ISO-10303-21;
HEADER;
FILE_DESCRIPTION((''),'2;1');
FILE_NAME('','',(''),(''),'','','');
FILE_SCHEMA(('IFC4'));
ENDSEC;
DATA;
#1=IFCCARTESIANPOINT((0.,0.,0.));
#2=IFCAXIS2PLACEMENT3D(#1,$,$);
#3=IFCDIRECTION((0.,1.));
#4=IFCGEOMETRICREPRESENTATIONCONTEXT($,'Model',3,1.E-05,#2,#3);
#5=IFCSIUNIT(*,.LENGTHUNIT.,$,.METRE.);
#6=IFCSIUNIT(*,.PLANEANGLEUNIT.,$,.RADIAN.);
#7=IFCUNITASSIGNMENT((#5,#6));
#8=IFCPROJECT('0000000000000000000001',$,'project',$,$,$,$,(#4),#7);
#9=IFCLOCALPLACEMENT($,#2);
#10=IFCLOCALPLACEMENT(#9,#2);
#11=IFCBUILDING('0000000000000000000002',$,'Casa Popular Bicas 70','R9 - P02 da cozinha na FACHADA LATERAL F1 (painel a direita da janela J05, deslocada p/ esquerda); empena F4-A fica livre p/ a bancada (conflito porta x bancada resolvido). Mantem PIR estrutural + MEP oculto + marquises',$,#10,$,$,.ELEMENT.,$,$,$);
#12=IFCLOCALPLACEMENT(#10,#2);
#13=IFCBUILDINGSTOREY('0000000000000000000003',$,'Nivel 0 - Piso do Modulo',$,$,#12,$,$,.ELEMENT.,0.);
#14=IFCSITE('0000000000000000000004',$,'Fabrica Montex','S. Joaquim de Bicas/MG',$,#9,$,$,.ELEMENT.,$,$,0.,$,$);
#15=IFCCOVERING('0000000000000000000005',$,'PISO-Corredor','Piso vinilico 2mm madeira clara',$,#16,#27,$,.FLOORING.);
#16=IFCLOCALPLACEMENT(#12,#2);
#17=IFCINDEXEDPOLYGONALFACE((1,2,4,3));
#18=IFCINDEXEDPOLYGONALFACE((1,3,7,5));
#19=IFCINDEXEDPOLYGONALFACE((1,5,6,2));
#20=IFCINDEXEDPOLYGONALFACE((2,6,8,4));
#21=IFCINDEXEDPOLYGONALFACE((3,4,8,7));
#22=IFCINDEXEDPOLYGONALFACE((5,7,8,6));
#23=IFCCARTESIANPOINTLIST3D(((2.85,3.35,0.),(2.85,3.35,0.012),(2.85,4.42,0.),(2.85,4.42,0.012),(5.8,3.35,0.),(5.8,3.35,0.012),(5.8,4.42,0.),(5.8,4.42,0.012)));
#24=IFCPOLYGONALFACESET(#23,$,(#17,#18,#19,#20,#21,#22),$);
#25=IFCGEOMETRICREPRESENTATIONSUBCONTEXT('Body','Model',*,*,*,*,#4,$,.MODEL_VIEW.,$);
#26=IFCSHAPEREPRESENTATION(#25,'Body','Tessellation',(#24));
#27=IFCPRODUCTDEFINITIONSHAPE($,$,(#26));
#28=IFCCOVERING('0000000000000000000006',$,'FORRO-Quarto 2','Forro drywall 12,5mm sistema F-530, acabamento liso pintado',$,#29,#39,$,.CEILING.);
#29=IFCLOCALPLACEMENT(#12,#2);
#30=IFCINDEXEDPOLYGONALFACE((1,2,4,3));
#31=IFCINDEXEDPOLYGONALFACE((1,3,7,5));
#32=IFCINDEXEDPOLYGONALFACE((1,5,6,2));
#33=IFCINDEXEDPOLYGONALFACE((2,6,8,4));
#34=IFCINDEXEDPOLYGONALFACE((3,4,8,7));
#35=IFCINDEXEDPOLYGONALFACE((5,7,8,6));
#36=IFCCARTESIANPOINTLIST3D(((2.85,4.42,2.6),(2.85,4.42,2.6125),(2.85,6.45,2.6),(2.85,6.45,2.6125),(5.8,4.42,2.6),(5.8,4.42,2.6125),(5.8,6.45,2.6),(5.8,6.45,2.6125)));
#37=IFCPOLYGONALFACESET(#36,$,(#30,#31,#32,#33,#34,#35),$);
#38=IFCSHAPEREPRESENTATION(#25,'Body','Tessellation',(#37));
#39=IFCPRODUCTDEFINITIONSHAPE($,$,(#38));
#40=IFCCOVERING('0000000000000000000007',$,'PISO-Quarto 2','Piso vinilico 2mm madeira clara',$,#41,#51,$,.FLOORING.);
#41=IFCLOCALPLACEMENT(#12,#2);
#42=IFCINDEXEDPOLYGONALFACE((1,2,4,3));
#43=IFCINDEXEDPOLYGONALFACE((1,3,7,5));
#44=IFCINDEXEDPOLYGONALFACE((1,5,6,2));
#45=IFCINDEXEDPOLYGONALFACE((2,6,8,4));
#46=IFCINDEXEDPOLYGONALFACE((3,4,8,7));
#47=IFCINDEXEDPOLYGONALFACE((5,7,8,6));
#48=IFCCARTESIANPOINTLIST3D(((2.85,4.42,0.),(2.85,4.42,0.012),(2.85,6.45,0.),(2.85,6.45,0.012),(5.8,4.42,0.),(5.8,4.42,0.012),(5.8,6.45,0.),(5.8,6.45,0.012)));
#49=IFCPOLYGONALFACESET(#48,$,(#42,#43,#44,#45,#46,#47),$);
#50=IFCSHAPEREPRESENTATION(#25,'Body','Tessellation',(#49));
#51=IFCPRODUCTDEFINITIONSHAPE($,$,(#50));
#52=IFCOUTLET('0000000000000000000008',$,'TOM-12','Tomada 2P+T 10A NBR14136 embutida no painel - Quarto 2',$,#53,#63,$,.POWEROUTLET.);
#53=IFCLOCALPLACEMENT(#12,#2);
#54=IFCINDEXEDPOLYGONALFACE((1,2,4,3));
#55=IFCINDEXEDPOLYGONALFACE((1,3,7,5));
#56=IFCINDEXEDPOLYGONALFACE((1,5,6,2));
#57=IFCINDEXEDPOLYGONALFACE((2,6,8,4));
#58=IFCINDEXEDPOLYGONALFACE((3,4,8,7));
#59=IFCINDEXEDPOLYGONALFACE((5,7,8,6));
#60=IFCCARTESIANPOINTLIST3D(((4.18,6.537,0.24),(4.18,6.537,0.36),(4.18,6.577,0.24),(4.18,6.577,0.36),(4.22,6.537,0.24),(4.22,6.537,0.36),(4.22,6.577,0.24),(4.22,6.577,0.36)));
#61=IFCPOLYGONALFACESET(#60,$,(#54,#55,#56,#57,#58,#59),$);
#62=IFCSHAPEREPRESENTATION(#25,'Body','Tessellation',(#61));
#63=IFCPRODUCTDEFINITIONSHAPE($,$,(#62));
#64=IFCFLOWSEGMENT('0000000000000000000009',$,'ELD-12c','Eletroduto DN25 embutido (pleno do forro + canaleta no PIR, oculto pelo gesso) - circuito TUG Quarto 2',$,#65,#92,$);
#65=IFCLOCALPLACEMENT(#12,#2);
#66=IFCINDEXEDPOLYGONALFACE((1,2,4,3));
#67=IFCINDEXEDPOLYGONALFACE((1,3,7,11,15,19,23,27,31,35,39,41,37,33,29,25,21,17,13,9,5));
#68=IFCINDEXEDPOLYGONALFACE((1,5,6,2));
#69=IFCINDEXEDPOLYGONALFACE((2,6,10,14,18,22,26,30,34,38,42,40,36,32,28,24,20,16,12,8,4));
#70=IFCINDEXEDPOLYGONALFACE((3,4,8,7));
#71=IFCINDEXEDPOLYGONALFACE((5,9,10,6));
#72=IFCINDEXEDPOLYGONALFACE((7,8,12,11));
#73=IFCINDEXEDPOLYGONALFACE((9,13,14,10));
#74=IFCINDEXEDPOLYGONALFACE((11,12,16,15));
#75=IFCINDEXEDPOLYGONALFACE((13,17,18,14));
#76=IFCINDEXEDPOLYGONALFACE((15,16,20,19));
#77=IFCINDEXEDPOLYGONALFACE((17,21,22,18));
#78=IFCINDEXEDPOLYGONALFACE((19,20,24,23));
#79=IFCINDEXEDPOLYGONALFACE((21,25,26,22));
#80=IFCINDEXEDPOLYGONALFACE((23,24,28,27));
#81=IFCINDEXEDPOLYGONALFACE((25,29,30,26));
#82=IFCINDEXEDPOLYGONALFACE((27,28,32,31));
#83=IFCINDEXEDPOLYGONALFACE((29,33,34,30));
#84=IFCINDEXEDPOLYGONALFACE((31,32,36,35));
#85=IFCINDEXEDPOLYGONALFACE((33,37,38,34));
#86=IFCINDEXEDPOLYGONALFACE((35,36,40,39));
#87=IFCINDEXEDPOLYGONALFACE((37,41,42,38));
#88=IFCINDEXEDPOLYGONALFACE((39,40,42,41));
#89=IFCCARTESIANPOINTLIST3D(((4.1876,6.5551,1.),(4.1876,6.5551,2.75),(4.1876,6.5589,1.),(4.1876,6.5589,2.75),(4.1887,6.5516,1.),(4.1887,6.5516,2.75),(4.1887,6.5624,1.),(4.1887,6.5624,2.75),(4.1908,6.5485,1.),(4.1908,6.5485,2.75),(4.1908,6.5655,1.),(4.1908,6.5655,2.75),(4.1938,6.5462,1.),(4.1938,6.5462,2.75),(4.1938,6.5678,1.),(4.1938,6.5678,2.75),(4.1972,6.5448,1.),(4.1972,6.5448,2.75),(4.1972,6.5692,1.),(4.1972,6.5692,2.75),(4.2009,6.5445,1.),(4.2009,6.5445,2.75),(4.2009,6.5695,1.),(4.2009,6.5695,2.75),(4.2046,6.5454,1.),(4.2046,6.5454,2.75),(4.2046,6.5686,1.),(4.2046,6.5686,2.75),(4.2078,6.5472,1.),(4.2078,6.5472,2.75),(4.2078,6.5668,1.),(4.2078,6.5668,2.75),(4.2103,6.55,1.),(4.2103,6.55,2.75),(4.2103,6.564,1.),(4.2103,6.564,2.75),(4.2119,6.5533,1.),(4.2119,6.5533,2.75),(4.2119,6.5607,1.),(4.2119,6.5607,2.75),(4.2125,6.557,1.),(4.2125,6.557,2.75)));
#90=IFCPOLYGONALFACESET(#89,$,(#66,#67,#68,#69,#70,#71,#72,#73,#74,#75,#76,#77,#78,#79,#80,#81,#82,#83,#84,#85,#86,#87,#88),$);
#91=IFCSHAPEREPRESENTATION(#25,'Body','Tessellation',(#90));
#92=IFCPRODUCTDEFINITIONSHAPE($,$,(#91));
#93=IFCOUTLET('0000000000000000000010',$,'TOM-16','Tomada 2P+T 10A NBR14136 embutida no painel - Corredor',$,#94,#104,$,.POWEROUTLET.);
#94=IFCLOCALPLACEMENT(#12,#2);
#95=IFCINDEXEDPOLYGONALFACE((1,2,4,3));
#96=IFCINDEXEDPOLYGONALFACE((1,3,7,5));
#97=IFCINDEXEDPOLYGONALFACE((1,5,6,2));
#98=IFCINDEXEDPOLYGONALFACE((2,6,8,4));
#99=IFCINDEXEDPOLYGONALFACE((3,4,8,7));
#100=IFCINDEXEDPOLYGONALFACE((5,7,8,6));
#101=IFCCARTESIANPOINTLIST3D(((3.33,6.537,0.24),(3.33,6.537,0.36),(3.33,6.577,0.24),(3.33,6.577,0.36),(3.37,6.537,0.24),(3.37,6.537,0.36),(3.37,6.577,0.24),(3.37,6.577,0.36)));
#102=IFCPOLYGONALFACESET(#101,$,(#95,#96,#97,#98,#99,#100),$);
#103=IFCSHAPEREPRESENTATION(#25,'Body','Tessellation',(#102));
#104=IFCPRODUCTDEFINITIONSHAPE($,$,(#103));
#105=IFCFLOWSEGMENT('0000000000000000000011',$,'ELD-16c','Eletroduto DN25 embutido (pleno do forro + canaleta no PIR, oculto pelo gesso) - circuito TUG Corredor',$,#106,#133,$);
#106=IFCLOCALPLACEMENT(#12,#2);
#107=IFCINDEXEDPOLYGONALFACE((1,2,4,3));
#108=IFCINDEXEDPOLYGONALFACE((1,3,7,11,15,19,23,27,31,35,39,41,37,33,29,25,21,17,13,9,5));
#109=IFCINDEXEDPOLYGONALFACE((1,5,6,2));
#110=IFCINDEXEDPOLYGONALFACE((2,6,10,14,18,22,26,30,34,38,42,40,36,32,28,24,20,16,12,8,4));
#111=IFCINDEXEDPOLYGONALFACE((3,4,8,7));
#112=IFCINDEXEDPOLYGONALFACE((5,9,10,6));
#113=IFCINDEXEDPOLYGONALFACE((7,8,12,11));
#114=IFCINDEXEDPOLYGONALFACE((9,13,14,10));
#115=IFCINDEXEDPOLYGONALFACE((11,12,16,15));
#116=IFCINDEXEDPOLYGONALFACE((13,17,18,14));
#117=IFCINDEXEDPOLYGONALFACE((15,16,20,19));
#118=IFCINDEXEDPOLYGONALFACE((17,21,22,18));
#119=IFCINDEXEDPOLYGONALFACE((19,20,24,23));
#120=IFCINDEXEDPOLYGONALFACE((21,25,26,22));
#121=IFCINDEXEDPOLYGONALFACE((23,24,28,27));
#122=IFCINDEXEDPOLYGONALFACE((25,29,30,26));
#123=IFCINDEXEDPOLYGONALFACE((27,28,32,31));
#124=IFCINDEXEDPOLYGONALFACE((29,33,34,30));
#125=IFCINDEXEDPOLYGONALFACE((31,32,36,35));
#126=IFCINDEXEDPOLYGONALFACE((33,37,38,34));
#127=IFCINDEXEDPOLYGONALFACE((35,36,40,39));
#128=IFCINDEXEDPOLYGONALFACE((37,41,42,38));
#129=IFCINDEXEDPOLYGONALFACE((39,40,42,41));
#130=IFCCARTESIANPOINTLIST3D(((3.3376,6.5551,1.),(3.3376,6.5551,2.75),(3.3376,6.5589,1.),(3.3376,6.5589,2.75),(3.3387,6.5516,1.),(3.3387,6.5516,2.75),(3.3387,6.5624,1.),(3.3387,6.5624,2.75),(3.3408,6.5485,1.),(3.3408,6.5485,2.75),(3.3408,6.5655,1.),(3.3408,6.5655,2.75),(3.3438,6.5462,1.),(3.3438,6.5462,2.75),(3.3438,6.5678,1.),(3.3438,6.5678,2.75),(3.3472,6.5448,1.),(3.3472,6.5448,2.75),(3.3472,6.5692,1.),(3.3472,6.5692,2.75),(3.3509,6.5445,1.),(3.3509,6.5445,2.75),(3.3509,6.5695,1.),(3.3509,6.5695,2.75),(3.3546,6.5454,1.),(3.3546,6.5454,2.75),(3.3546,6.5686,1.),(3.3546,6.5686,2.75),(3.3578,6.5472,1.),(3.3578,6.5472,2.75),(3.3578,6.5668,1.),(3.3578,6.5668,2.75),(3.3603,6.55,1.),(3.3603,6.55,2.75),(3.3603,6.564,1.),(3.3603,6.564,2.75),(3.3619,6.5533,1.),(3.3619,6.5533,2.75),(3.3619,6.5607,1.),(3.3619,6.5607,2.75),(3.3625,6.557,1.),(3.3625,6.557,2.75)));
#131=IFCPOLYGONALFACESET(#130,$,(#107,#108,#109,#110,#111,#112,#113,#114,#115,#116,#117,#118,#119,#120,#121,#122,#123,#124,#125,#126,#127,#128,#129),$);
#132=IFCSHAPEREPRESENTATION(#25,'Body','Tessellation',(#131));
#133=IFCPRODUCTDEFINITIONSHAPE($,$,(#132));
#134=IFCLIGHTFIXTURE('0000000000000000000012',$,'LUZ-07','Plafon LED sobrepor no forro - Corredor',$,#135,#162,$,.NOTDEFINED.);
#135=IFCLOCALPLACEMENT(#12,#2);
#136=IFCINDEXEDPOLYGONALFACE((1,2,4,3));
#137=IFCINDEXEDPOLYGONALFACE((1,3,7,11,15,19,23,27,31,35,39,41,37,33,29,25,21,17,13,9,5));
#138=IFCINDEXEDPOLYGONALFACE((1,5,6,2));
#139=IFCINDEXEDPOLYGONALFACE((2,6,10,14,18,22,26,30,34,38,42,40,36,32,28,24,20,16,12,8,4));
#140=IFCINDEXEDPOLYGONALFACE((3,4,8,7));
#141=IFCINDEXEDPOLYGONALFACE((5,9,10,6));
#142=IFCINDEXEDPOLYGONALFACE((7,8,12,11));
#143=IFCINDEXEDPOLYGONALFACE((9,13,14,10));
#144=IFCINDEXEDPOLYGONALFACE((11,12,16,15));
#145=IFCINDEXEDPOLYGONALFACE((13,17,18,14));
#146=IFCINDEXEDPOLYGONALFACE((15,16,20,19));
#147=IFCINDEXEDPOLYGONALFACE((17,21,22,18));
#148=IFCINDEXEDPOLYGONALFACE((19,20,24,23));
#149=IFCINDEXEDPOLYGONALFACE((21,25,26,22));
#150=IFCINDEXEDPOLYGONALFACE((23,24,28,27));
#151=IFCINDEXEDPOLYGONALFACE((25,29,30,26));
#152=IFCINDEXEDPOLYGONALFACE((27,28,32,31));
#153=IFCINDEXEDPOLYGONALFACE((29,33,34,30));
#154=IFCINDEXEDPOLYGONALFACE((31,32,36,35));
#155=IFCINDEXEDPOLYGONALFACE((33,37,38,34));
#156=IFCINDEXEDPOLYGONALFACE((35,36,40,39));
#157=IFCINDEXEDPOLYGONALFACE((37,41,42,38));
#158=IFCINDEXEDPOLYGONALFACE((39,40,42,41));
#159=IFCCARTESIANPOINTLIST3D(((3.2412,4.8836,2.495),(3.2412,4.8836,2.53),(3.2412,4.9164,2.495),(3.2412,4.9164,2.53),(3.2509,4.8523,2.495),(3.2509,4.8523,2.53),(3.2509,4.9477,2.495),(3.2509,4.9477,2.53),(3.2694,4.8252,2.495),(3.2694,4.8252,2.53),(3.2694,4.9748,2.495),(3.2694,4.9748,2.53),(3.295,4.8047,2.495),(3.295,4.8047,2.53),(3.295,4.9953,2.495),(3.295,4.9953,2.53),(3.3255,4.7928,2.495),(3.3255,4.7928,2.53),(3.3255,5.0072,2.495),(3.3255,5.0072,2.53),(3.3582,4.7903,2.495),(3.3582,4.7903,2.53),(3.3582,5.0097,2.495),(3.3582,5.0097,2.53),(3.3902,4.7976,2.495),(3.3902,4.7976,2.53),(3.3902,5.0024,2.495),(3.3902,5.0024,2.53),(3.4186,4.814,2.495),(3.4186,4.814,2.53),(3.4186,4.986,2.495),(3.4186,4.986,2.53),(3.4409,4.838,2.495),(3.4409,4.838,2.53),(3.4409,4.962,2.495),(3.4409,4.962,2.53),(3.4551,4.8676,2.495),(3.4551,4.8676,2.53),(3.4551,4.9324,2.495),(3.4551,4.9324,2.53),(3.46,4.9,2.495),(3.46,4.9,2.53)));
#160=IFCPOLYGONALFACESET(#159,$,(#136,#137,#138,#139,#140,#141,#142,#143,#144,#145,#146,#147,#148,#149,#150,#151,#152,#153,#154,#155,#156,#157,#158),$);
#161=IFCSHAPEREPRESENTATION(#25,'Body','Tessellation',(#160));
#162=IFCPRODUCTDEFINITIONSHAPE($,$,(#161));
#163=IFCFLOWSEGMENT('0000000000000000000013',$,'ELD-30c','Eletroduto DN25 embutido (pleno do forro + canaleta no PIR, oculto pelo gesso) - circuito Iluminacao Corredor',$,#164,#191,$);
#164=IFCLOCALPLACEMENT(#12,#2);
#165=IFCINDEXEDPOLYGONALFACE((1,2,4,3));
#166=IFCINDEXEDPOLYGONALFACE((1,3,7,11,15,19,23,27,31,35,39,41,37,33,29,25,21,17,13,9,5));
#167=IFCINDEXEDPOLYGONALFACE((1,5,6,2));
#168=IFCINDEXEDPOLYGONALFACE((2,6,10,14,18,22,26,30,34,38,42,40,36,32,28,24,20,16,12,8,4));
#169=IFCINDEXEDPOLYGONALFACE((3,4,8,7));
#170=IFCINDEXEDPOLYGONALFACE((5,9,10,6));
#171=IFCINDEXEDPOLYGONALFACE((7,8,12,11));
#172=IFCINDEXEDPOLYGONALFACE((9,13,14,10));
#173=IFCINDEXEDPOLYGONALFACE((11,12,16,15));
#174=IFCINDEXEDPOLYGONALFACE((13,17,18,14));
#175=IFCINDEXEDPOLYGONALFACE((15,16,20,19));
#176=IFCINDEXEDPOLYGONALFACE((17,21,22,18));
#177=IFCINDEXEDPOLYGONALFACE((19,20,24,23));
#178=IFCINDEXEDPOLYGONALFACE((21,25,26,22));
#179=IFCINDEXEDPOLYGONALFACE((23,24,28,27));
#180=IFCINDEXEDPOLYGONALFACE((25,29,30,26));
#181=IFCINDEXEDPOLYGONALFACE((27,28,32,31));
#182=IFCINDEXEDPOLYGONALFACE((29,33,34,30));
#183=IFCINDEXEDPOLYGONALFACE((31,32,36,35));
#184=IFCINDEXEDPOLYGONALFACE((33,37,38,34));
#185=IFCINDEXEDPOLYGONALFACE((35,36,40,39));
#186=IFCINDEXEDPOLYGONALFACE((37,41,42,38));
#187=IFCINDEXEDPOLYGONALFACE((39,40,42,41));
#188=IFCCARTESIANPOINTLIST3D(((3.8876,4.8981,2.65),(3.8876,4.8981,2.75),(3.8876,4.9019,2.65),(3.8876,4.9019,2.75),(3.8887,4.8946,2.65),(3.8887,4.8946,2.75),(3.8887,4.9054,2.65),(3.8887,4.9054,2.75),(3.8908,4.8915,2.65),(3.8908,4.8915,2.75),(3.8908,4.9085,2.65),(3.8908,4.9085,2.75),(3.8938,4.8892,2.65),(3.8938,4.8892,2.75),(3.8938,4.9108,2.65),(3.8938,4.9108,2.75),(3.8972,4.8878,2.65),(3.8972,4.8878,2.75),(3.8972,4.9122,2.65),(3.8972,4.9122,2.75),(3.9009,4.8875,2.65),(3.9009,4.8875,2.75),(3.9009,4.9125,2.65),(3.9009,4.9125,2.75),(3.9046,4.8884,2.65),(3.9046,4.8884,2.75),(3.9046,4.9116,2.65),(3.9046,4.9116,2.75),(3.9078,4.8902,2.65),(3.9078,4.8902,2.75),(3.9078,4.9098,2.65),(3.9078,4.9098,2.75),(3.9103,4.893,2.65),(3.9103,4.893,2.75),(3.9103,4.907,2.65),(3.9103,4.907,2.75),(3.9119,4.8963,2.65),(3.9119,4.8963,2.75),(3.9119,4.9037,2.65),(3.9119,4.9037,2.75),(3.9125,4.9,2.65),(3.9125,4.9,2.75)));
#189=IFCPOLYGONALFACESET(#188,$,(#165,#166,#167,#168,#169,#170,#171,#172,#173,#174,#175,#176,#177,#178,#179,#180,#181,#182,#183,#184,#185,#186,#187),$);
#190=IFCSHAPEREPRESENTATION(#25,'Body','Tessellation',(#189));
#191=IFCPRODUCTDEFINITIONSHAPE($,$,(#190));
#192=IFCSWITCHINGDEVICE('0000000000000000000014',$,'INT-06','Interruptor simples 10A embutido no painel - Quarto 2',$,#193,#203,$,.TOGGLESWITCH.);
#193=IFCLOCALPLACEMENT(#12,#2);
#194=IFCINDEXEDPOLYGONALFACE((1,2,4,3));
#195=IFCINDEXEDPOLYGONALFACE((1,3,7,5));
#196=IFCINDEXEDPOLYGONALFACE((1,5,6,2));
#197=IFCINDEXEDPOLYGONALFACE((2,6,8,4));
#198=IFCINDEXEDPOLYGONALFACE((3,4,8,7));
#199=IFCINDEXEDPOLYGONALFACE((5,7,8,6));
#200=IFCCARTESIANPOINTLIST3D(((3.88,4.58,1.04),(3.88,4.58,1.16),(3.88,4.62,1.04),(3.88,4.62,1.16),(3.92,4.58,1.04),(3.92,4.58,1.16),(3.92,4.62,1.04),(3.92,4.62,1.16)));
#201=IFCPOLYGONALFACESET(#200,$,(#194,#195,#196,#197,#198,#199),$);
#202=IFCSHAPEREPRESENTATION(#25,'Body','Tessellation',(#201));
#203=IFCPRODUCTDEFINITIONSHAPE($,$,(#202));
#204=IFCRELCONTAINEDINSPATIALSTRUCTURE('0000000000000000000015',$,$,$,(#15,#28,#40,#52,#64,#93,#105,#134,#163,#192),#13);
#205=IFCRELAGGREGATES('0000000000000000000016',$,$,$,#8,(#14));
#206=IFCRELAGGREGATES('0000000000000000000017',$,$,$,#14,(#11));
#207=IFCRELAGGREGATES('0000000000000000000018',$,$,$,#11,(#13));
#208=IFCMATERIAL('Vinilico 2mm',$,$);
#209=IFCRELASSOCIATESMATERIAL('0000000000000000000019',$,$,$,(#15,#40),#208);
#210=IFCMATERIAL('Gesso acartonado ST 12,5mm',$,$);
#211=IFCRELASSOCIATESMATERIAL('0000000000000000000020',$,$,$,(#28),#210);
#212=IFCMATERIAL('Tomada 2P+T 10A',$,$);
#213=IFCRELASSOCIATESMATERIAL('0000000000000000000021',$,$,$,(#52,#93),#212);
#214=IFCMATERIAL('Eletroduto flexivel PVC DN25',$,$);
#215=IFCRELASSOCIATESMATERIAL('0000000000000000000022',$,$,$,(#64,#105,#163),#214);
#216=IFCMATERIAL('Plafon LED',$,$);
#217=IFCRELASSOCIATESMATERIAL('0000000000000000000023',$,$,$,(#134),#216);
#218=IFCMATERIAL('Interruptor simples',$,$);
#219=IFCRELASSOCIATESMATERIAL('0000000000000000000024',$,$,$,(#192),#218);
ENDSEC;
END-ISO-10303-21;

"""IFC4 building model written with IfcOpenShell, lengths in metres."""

from ifc_helpers import new_model, si_unit, direction, frame, frame_2d, origin, origin_2d, place, context, subcontext, project, spatial, rectangle, circle, extrude, material, element, save


model = new_model("IFC4")

# Units and contexts
model_context = context("Model", 3, precision=1e-05, world=origin(), true_north=direction((0.0, 1.0)))
body_context = subcontext(model_context, "Body", "Model", "MODEL_VIEW")
ifc_project = project(units=[si_unit("LENGTHUNIT", "METRE"), si_unit("PLANEANGLEUNIT", "RADIAN")], contexts=[model_context])

# Site, building, storey
site_placement = place(None, origin())
site = spatial("IfcSite", under=ifc_project, at=site_placement, Name="Fabrica Montex", Description="S. Joaquim de Bicas/MG", CompositionType="ELEMENT", RefElevation=0.0)
building_placement = place(site_placement, origin())
building = spatial("IfcBuilding", under=site, at=building_placement, Name="Casa Popular Bicas 70", Description="R9 - P02 da cozinha na FACHADA LATERAL F1 (painel a direita da janela J05, deslocada p/ esquerda); empena F4-A fica livre p/ a bancada (conflito porta x bancada resolvido). Mantem PIR estrutural + MEP oculto + marquises", CompositionType="ELEMENT")
storey_placement = place(building_placement, origin())
storey = spatial("IfcBuildingStorey", under=building, at=storey_placement, Name="Nivel 0 - Piso do Modulo", CompositionType="ELEMENT", Elevation=0.0)

# Coverings
ifc_material_1 = material(Name="Vinilico 2mm")
covering_1_placement = place(storey_placement, frame((2.85, 3.35, 0.0)))
element("IfcCovering", 1, at=covering_1_placement, inside=storey, material=ifc_material_1, Name="PISO-Corredor", Description="Piso vinilico 2mm madeira clara", PredefinedType="FLOORING", context=body_context, shape_type="SweptSolid", body=[
    extrude(rectangle(XDim=2.95, YDim=1.07, at=frame_2d((1.475, 0.535))), origin(), (0.0, 0.0, 1.0), 0.012),
])
ifc_material_2 = material(Name="Gesso acartonado ST 12,5mm")
covering_2_placement = place(storey_placement, frame((2.85, 4.42, 2.6)))
element("IfcCovering", 2, at=covering_2_placement, inside=storey, material=ifc_material_2, Name="FORRO-Quarto 2", Description="Forro drywall 12,5mm sistema F-530, acabamento liso pintado", PredefinedType="CEILING", context=body_context, shape_type="SweptSolid", body=[
    extrude(rectangle(XDim=2.95, YDim=2.03, at=frame_2d((1.475, 1.015))), origin(), (0.0, 0.0, 1.0), 0.0125),
])
covering_3_placement = place(storey_placement, frame((2.85, 4.42, 0.0)))
element("IfcCovering", 3, at=covering_3_placement, inside=storey, material=ifc_material_1, Name="PISO-Quarto 2", Description="Piso vinilico 2mm madeira clara", PredefinedType="FLOORING", context=body_context, shape_type="SweptSolid", body=[
    extrude(rectangle(XDim=2.95, YDim=2.03, at=frame_2d((1.475, 1.015))), origin(), (0.0, 0.0, 1.0), 0.012),
])

# Outlet
ifc_material_3 = material(Name="Tomada 2P+T 10A")
outlet_1_placement = place(storey_placement, frame((4.18, 6.537, 0.24)))
element("IfcOutlet", 4, at=outlet_1_placement, inside=storey, material=ifc_material_3, Name="TOM-12", Description="Tomada 2P+T 10A NBR14136 embutida no painel - Quarto 2", PredefinedType="POWEROUTLET", context=body_context, shape_type="SweptSolid", body=[
    extrude(rectangle(XDim=0.04, YDim=0.04, at=frame_2d((0.02, 0.02))), origin(), (0.0, 0.0, 1.0), 0.12),
])

# Flow segment
ifc_material_4 = material(Name="Eletroduto flexivel PVC DN25")
flow_segment_1_placement = place(storey_placement, frame((4.2, 6.557, 2.75), z_axis=(0.0, 0.0, -1.0), x_axis=(1.0, 0.0, 0.0)))
element("IfcFlowSegment", 5, at=flow_segment_1_placement, inside=storey, material=ifc_material_4, Name="ELD-12c", Description="Eletroduto DN25 embutido (pleno do forro + canaleta no PIR, oculto pelo gesso) - circuito TUG Quarto 2", context=body_context, shape_type="SweptSolid", body=[
    extrude(circle(Radius=0.0125, at=origin_2d()), origin(), (0.0, 0.0, 1.0), 1.75),
])

# Outlet
outlet_2_placement = place(storey_placement, frame((3.33, 6.537, 0.24)))
element("IfcOutlet", 6, at=outlet_2_placement, inside=storey, material=ifc_material_3, Name="TOM-16", Description="Tomada 2P+T 10A NBR14136 embutida no painel - Corredor", PredefinedType="POWEROUTLET", context=body_context, shape_type="SweptSolid", body=[
    extrude(rectangle(XDim=0.04, YDim=0.04, at=frame_2d((0.02, 0.02))), origin(), (0.0, 0.0, 1.0), 0.12),
])

# Flow segment
flow_segment_2_placement = place(storey_placement, frame((3.35, 6.557, 2.75), z_axis=(0.0, 0.0, -1.0), x_axis=(1.0, 0.0, 0.0)))
element("IfcFlowSegment", 7, at=flow_segment_2_placement, inside=storey, material=ifc_material_4, Name="ELD-16c", Description="Eletroduto DN25 embutido (pleno do forro + canaleta no PIR, oculto pelo gesso) - circuito TUG Corredor", context=body_context, shape_type="SweptSolid", body=[
    extrude(circle(Radius=0.0125, at=origin_2d()), origin(), (0.0, 0.0, 1.0), 1.75),
])

# Light fixture
ifc_material_5 = material(Name="Plafon LED")
light_fixture_placement = place(storey_placement, frame((3.35, 4.9, 2.495)))
element("IfcLightFixture", 8, at=light_fixture_placement, inside=storey, material=ifc_material_5, Name="LUZ-07", Description="Plafon LED sobrepor no forro - Corredor", PredefinedType="NOTDEFINED", context=body_context, shape_type="SweptSolid", body=[
    extrude(circle(Radius=0.11, at=origin_2d()), origin(), (0.0, 0.0, 1.0), 0.035),
])

# Flow segment
flow_segment_3_placement = place(storey_placement, frame((3.9, 4.9, 2.75), z_axis=(0.0, 0.0, -1.0), x_axis=(1.0, 0.0, 0.0)))
element("IfcFlowSegment", 9, at=flow_segment_3_placement, inside=storey, material=ifc_material_4, Name="ELD-30c", Description="Eletroduto DN25 embutido (pleno do forro + canaleta no PIR, oculto pelo gesso) - circuito Iluminacao Corredor", context=body_context, shape_type="SweptSolid", body=[
    extrude(circle(Radius=0.0125, at=origin_2d()), origin(), (0.0, 0.0, 1.0), 0.1),
])

# Switching device
ifc_material_6 = material(Name="Interruptor simples")
switching_device_placement = place(storey_placement, frame((3.88, 4.58, 1.04)))
element("IfcSwitchingDevice", 10, at=switching_device_placement, inside=storey, material=ifc_material_6, Name="INT-06", Description="Interruptor simples 10A embutido no painel - Quarto 2", PredefinedType="TOGGLESWITCH", context=body_context, shape_type="SweptSolid", body=[
    extrude(rectangle(XDim=0.04, YDim=0.04, at=frame_2d((0.02, 0.02))), origin(), (0.0, 0.0, 1.0), 0.12),
])

save(model, "model.ifc")
